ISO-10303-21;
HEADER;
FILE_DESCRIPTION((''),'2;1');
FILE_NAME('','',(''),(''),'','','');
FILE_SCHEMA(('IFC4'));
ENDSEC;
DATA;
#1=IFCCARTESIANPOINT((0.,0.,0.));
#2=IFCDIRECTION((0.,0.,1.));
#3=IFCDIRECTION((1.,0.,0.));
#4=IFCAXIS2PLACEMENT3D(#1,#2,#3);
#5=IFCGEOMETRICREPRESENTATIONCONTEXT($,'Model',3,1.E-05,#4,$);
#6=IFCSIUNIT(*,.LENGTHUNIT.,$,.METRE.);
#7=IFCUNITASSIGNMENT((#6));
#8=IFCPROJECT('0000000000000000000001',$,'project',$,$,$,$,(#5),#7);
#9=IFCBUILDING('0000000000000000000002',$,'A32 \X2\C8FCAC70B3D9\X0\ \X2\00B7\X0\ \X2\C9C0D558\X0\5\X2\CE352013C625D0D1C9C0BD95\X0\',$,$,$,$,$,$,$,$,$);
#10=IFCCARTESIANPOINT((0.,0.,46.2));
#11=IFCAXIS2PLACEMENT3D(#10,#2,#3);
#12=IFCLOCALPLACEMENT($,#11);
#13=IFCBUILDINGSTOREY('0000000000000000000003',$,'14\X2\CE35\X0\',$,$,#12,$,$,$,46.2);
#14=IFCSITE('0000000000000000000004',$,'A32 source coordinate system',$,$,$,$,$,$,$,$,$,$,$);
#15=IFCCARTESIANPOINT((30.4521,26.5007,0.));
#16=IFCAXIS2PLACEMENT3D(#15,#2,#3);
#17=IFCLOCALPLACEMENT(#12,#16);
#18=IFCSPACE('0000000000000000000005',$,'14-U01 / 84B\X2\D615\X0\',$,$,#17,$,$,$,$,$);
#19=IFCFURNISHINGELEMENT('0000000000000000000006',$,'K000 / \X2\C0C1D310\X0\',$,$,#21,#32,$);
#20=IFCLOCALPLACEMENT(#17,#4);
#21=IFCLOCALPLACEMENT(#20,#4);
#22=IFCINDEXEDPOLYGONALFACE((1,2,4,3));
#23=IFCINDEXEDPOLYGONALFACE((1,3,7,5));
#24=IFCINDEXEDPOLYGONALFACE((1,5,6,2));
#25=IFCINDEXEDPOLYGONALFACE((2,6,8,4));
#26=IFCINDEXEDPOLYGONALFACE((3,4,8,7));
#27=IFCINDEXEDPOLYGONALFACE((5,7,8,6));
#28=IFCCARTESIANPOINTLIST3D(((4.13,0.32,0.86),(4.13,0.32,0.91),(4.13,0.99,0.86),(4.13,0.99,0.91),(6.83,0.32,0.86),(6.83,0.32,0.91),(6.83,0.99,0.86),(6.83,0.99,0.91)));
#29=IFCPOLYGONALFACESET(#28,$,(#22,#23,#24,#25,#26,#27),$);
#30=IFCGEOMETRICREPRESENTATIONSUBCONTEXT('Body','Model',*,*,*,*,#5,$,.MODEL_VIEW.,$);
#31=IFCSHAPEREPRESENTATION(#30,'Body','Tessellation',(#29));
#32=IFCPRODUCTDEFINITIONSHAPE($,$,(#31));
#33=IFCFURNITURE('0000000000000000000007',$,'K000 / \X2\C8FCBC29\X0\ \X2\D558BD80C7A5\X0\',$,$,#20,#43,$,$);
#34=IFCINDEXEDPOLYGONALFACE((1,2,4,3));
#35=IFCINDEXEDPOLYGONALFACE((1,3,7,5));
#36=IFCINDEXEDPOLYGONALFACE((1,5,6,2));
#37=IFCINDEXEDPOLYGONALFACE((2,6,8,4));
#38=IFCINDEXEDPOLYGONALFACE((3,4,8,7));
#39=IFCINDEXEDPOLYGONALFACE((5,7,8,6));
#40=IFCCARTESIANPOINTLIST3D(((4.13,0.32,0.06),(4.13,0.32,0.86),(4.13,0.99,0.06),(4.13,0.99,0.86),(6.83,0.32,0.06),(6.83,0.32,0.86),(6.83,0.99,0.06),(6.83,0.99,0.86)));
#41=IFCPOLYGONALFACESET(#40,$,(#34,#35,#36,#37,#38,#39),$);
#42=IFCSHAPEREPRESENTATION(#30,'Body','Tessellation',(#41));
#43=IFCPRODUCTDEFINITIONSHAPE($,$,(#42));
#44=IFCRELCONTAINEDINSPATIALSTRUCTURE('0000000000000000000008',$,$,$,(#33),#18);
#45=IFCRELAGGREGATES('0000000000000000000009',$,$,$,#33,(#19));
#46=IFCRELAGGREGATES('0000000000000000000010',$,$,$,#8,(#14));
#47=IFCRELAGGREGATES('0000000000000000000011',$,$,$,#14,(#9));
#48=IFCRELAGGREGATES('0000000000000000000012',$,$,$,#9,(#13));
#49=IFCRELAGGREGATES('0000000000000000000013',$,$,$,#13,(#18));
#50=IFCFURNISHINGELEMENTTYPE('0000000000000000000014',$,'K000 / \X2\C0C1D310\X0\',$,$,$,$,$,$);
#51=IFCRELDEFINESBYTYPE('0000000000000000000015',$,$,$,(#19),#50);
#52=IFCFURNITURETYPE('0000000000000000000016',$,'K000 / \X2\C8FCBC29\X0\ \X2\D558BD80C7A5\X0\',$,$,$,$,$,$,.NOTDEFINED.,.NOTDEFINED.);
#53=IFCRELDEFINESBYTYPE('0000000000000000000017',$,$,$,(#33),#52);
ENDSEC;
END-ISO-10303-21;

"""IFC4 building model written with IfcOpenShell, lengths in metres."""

from ifc_helpers import new_model, si_unit, frame, origin, origin_with_axes, place, context, subcontext, project, spatial, polyline, outline, extrude, source, transform, mapped, type_object, type_shapes, element, aggregate, save


model = new_model("IFC4")

# Units and contexts
model_context = context("Model", 3, precision=1e-05, world=origin_with_axes())
body_context = subcontext(model_context, "Body", "Model", "MODEL_VIEW")
ifc_project = project(units=[si_unit("LENGTHUNIT", "METRE")], contexts=[model_context])

# Site, building, storey, space
site = spatial("IfcSite", under=ifc_project, Name="A32 source coordinate system")
building = spatial("IfcBuilding", under=site, Name="A32 주거동 · 지하5층–옥탑지붕")
storey_placement = place(None, frame((0.0, 0.0, 46.2), z_axis=(0.0, 0.0, 1.0), x_axis=(1.0, 0.0, 0.0)))
storey = spatial("IfcBuildingStorey", under=building, at=storey_placement, Name="14층", Elevation=46.2)
space_placement = place(storey_placement, frame((30.4521, 26.5007, 0.0), z_axis=(0.0, 0.0, 1.0), x_axis=(1.0, 0.0, 0.0)))
space = spatial("IfcSpace", under=storey, at=space_placement, Name="14-U01 / 84B형")

# Furnishing element
furnishing_element_type = type_object("IfcFurnishingElementType", Name="K000 / 상판")
shared_shape_1 = source(origin(), body_context, "Body", "SweptSolid", [
    extrude(outline(polyline([(4.13, 0.32), (4.13, 0.99), (6.83, 0.99), (6.83, 0.32), (4.13, 0.32)])), frame((0.0, 0.0, 0.86)), (0.0, 0.0, 1.0), 0.05),
])
type_shapes(furnishing_element_type, [shared_shape_1])
furniture_placement = place(space_placement, origin_with_axes())
furnishing_placement = place(furniture_placement, origin_with_axes())
furnishing = element("IfcFurnishingElement", 1, at=furnishing_placement, type_object=furnishing_element_type, Name="K000 / 상판", context=body_context, shape_type="MappedRepresentation", body=[
    mapped(shared_shape_1, transform((0.0, 0.0, 0.0), scale=1.0)),
])

# Furniture
furniture_type = type_object("IfcFurnitureType", Name="K000 / 주방 하부장", AssemblyPlace="NOTDEFINED", PredefinedType="NOTDEFINED")
shared_shape_2 = source(origin(), body_context, "Body", "SweptSolid", [
    extrude(outline(polyline([(6.83, 0.32), (4.13, 0.32), (4.13, 0.99), (6.83, 0.99), (6.83, 0.32)])), frame((0.0, 0.0, 0.06)), (0.0, 0.0, 1.0), 0.8),
])
type_shapes(furniture_type, [shared_shape_2])
furniture = element("IfcFurniture", 2, at=furniture_placement, inside=space, type_object=furniture_type, Name="K000 / 주방 하부장", context=body_context, shape_type="MappedRepresentation", body=[
    mapped(shared_shape_2, transform((0.0, 0.0, 0.0), scale=1.0)),
])
aggregate(furniture, [furnishing])

save(model, "model.ifc")
